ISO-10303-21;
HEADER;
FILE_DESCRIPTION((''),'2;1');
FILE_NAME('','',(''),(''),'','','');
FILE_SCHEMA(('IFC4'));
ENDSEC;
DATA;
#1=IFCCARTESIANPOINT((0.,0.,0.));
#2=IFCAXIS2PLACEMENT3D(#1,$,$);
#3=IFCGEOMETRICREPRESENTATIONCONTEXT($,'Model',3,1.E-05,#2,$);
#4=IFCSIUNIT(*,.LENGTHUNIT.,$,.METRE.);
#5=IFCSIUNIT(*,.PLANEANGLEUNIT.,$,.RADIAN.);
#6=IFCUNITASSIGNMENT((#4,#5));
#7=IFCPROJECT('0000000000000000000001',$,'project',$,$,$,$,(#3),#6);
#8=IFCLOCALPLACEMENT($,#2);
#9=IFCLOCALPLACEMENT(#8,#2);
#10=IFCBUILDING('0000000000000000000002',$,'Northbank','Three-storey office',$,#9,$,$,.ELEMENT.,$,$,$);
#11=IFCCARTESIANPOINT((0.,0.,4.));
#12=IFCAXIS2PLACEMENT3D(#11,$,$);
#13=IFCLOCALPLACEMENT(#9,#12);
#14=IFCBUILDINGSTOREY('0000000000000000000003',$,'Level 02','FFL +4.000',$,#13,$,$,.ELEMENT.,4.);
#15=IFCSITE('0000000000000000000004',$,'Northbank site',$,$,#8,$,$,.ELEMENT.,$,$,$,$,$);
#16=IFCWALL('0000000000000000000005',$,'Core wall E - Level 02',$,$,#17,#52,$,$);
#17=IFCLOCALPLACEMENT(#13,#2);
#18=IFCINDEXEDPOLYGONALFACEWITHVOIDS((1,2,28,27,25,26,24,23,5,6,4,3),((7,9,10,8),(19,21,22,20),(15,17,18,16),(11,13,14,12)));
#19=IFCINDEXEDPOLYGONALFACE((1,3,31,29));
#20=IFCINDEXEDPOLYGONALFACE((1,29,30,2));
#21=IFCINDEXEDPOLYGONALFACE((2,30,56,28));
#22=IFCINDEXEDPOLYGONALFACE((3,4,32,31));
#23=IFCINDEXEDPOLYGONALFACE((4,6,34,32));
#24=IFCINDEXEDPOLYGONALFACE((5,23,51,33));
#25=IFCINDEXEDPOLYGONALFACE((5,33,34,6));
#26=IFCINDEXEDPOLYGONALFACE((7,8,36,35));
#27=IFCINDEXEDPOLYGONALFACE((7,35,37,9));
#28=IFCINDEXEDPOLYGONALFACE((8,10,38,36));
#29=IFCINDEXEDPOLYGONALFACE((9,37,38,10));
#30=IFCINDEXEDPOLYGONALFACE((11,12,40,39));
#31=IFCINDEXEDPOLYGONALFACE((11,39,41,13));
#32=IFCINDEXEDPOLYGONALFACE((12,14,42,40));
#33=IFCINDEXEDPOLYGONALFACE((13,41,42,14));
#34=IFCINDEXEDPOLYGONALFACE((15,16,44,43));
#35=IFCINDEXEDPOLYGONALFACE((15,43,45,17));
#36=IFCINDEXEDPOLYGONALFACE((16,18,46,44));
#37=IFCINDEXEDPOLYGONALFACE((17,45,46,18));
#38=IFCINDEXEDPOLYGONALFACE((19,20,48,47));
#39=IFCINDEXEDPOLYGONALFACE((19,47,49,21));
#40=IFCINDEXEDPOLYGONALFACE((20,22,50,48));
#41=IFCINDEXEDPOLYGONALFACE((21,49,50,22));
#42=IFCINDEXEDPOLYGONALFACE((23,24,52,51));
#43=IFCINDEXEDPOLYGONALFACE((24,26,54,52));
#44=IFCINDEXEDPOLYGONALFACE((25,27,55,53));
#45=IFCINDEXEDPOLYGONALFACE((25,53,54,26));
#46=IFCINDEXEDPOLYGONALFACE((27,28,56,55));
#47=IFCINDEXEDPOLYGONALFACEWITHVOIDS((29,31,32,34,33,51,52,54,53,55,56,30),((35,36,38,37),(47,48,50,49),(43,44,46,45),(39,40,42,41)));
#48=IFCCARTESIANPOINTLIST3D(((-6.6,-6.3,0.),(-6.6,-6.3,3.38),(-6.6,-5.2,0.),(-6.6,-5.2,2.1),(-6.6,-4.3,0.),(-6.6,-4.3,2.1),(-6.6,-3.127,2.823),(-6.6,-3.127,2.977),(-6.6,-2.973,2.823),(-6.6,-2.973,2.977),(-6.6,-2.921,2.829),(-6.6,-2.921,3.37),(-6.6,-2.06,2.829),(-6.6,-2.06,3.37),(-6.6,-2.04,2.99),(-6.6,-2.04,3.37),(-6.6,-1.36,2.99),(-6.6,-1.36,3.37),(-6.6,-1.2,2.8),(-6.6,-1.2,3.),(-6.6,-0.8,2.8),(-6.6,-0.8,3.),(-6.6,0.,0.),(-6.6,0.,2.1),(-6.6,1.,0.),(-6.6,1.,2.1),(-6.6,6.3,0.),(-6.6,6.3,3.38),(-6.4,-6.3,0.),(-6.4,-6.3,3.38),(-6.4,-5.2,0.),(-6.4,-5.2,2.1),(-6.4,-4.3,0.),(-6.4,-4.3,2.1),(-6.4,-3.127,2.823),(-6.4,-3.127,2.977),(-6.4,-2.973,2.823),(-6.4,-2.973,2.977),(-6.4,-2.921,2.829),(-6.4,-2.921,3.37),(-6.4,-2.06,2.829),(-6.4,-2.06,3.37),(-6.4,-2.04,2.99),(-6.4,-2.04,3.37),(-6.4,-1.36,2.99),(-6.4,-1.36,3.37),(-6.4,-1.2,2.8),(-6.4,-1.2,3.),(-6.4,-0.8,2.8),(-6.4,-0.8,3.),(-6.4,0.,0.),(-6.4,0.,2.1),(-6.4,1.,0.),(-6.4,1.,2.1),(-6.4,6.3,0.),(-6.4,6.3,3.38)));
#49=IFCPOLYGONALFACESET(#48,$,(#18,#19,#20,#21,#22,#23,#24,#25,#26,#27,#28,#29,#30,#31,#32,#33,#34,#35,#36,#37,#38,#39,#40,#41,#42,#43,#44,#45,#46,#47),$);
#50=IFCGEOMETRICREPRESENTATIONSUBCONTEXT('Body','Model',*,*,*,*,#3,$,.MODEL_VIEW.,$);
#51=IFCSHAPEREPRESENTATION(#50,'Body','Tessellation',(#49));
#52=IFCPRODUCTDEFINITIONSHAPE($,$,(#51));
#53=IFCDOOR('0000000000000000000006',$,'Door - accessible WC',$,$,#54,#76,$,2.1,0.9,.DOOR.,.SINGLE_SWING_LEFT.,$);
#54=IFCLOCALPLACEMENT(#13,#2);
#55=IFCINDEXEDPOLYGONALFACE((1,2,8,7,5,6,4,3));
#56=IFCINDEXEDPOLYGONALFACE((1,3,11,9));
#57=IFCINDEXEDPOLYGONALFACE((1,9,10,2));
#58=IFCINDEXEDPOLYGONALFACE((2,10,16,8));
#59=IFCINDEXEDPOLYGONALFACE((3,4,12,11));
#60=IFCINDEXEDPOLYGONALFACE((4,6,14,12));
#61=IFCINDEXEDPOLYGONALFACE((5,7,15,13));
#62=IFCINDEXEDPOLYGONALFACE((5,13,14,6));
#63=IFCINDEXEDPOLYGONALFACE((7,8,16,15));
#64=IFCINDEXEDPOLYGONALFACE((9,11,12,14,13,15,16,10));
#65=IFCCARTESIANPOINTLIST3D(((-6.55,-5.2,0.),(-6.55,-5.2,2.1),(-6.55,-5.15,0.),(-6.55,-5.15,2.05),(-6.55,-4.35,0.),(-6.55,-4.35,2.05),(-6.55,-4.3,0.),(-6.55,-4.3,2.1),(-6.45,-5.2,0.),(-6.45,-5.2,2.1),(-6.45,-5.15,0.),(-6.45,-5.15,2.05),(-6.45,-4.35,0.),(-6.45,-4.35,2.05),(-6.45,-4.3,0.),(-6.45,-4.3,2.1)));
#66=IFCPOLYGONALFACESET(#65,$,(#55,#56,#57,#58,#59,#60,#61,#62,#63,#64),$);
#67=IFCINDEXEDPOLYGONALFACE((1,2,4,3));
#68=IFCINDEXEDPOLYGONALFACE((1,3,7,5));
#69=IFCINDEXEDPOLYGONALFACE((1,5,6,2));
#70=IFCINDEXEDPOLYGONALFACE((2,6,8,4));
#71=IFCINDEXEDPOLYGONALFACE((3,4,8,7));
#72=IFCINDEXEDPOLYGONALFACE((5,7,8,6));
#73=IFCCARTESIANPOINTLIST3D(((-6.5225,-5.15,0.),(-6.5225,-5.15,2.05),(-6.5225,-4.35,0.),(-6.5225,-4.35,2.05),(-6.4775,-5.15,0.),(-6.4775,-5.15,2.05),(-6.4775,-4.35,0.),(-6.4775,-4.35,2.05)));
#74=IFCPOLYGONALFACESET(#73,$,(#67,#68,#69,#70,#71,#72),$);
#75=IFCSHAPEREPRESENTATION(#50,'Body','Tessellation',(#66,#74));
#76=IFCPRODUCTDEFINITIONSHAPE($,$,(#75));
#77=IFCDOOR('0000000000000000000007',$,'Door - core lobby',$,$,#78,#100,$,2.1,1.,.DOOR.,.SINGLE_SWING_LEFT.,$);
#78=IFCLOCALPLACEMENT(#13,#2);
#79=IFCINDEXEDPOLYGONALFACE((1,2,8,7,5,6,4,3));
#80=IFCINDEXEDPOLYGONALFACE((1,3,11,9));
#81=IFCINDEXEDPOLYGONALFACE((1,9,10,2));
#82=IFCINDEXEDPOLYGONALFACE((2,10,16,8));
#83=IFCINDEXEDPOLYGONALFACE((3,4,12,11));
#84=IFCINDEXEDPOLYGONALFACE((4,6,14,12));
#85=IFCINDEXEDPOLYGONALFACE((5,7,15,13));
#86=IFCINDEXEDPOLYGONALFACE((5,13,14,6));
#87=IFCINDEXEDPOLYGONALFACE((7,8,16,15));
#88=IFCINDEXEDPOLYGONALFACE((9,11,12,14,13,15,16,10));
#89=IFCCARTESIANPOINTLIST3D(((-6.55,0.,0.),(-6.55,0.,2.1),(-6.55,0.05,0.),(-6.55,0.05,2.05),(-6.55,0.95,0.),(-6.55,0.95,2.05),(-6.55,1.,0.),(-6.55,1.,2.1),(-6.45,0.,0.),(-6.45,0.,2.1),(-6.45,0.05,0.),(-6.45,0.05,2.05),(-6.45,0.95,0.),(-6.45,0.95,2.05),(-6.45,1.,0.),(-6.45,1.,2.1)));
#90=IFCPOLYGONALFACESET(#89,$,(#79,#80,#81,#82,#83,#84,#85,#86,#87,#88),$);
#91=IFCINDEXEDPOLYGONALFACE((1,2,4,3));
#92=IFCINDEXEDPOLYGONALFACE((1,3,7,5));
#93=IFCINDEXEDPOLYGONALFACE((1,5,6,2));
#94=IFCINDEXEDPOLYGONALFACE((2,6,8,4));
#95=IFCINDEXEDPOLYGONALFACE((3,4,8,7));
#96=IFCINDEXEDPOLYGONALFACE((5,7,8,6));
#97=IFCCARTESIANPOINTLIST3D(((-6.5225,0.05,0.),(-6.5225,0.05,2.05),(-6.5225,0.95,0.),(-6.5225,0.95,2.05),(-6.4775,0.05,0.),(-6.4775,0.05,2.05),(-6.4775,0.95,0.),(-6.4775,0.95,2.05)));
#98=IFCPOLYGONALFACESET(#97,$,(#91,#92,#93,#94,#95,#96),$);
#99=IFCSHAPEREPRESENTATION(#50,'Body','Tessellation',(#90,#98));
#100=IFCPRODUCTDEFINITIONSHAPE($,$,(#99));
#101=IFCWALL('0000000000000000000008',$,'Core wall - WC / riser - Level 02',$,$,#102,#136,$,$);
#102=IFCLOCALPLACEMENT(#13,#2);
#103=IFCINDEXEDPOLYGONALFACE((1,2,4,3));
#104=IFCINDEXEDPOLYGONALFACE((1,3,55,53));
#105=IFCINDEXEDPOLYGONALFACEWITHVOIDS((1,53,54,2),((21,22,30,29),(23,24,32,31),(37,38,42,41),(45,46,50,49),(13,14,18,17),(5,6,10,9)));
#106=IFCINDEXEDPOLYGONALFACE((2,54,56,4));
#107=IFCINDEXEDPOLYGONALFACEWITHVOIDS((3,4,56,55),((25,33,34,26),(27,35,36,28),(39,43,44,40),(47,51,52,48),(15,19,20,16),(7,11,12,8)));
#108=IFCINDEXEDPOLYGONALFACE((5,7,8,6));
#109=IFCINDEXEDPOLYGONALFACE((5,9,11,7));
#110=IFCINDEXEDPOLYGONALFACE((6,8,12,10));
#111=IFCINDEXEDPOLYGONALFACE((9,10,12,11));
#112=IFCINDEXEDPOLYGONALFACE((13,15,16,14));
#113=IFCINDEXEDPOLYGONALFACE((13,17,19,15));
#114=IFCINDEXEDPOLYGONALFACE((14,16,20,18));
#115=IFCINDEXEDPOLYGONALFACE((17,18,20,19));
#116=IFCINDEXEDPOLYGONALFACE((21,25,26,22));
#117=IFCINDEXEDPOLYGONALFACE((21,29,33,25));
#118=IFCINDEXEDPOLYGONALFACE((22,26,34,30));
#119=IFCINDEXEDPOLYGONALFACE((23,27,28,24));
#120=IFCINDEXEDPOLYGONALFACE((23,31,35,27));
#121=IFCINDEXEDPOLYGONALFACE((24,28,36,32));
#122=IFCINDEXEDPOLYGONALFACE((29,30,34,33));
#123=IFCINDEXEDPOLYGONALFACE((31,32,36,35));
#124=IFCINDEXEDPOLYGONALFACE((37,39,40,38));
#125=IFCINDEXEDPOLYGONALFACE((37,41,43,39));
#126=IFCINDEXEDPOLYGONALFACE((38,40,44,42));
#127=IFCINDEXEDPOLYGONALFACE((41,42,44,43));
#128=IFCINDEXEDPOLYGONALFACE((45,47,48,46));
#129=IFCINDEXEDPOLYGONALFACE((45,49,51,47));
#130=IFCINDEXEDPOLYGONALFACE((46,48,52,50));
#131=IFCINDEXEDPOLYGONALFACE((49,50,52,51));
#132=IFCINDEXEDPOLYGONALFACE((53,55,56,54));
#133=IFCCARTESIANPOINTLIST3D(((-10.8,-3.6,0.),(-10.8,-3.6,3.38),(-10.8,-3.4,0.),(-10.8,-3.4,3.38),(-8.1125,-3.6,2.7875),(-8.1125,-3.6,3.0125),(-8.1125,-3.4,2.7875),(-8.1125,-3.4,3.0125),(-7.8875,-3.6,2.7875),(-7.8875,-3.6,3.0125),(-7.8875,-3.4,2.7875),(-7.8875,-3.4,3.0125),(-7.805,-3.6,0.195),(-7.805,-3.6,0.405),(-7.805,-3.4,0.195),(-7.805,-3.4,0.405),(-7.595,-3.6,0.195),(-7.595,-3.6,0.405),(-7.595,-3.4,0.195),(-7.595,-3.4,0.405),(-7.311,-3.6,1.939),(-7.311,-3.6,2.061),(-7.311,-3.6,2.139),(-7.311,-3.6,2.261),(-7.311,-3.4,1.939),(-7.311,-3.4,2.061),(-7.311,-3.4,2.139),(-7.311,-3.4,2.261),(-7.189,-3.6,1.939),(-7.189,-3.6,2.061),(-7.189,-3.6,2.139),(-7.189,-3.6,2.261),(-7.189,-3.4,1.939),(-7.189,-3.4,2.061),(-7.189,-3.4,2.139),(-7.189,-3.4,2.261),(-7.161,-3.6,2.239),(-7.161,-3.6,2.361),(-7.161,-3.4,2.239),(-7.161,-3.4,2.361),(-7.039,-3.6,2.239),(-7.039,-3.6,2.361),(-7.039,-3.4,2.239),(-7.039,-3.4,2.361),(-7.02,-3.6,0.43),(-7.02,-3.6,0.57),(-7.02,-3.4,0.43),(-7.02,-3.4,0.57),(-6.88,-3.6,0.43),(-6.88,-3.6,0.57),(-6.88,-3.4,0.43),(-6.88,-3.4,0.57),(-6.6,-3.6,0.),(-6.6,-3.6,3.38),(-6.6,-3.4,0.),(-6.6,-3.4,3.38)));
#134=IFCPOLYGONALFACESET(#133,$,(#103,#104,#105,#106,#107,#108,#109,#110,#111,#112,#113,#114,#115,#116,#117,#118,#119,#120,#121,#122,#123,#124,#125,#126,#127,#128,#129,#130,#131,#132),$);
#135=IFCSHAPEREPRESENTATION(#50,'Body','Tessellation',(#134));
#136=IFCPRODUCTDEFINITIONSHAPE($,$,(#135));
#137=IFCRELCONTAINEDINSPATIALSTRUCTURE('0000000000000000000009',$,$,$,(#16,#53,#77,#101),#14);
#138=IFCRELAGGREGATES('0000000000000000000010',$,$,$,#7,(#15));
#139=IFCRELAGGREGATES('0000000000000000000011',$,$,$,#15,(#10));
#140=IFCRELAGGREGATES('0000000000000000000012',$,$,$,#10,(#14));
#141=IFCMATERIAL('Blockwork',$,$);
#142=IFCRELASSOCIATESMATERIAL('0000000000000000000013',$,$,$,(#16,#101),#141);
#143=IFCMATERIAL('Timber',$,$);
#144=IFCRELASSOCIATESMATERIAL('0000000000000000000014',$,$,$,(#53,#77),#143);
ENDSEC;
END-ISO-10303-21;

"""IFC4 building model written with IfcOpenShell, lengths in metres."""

from ifc_helpers import new_model, si_unit, frame, origin, place, context, subcontext, project, spatial, polyline, outline, extrude, material, element, fill, save


model = new_model("IFC4")

# Units and contexts
model_context = context("Model", 3, precision=1e-05, world=origin())
body_context = subcontext(model_context, "Body", "Model", "MODEL_VIEW")
ifc_project = project(units=[si_unit("LENGTHUNIT", "METRE"), si_unit("PLANEANGLEUNIT", "RADIAN")], contexts=[model_context])

# Site, building, storey
site_placement = place(None, origin())
site = spatial("IfcSite", under=ifc_project, at=site_placement, Name="Northbank site", CompositionType="ELEMENT")
building_placement = place(site_placement, origin())
building = spatial("IfcBuilding", under=site, at=building_placement, Name="Northbank", Description="Three-storey office", CompositionType="ELEMENT")
storey_placement = place(building_placement, frame((0.0, 0.0, 4.0)))
storey = spatial("IfcBuildingStorey", under=building, at=storey_placement, Name="Level 02", Description="FFL +4.000", CompositionType="ELEMENT", Elevation=4.0)

# Wall, openings, doors
ifc_material_1 = material(Name="Blockwork")
wall_1_placement = place(storey_placement, frame((0.0, 0.0, -4.0)))
wall_1 = element("IfcWall", 1, at=wall_1_placement, inside=storey, material=ifc_material_1, Name="Core wall E - Level 02", context=body_context, shape_type="SweptSolid", body=[
    extrude(outline(polyline([(0.0, 0.0), (1.1, 0.0), (1.1, 2.1), (2.0, 2.1), (2.0, 0.0), (6.3, 0.0), (6.3, 2.1), (7.3, 2.1), (7.3, 0.0), (12.6, 0.0), (12.6, 3.38), (0.0, 3.38), (0.0, 0.0)]), holes=[polyline([(3.379, 2.829), (3.379, 3.37), (4.24, 3.37), (4.24, 2.829), (3.379, 2.829)]), polyline([(4.26, 2.99), (4.26, 3.37), (4.94, 3.37), (4.94, 2.99), (4.26, 2.99)]), polyline([(3.173, 2.823), (3.173, 2.977), (3.327, 2.977), (3.327, 2.823), (3.173, 2.823)]), polyline([(5.1, 2.8), (5.1, 3.0), (5.5, 3.0), (5.5, 2.8), (5.1, 2.8)])]), frame((-6.6, -6.3, 4.0), z_axis=(1.0, 0.0, 0.0), x_axis=(0.0, 1.0, 0.0)), (0.0, 0.0, 1.0), 0.2),
])
opening_1_placement = place(storey_placement, frame((0.0, 0.0, -4.0)))
opening_1 = element("IfcOpeningElement", 2, at=opening_1_placement, cuts=wall_1, PredefinedType="OPENING", context=body_context, shape_type="SweptSolid", body=[
    extrude(outline(polyline([(0.0, 0.0), (0.9, 0.0), (0.9, 2.1), (0.0, 2.1), (0.0, 0.0)])), frame((-6.65, -5.2, 4.0), z_axis=(1.0, 0.0, 0.0), x_axis=(0.0, 1.0, 0.0)), (0.0, 0.0, 1.0), 0.3),
])
opening_2_placement = place(storey_placement, frame((0.0, 0.0, -4.0)))
opening_2 = element("IfcOpeningElement", 3, at=opening_2_placement, cuts=wall_1, PredefinedType="OPENING", context=body_context, shape_type="SweptSolid", body=[
    extrude(outline(polyline([(0.0, 0.0), (1.0, 0.0), (1.0, 2.1), (0.0, 2.1), (0.0, 0.0)])), frame((-6.65, 0.0, 4.0), z_axis=(1.0, 0.0, 0.0), x_axis=(0.0, 1.0, 0.0)), (0.0, 0.0, 1.0), 0.3),
])
ifc_material_2 = material(Name="Timber")
door_1_placement = place(storey_placement, frame((0.0, 0.0, -4.0)))
door_1 = element("IfcDoor", 4, at=door_1_placement, inside=storey, material=ifc_material_2, Name="Door - accessible WC", OperationType="SINGLE_SWING_LEFT", OverallHeight=2.1, OverallWidth=0.9, PredefinedType="DOOR", context=body_context, shape_type="SweptSolid", body=[
    extrude(outline(polyline([(0.0, 0.0), (0.05, 0.0), (0.05, 2.05), (0.85, 2.05), (0.85, 0.0), (0.9, 0.0), (0.9, 2.1), (0.0, 2.1), (0.0, 0.0)])), frame((-6.55, -5.2, 4.0), z_axis=(1.0, 0.0, 0.0), x_axis=(0.0, 1.0, 0.0)), (0.0, 0.0, 1.0), 0.1),
    extrude(outline(polyline([(0.0, 0.0), (0.8, 0.0), (0.8, 2.05), (0.0, 2.05), (0.0, 0.0)])), frame((-6.5225, -5.15, 4.0), z_axis=(1.0, 0.0, 0.0), x_axis=(0.0, 1.0, 0.0)), (0.0, 0.0, 1.0), 0.045),
])
fill(opening_1, door_1)
door_2_placement = place(storey_placement, frame((0.0, 0.0, -4.0)))
door_2 = element("IfcDoor", 5, at=door_2_placement, inside=storey, material=ifc_material_2, Name="Door - core lobby", OperationType="SINGLE_SWING_LEFT", OverallHeight=2.1, OverallWidth=1.0, PredefinedType="DOOR", context=body_context, shape_type="SweptSolid", body=[
    extrude(outline(polyline([(0.0, 0.0), (0.05, 0.0), (0.05, 2.05), (0.95, 2.05), (0.95, 0.0), (1.0, 0.0), (1.0, 2.1), (0.0, 2.1), (0.0, 0.0)])), frame((-6.55, 0.0, 4.0), z_axis=(1.0, 0.0, 0.0), x_axis=(0.0, 1.0, 0.0)), (0.0, 0.0, 1.0), 0.1),
    extrude(outline(polyline([(0.0, 0.0), (0.9, 0.0), (0.9, 2.05), (0.0, 2.05), (0.0, 0.0)])), frame((-6.5225, 0.05, 4.0), z_axis=(1.0, 0.0, 0.0), x_axis=(0.0, 1.0, 0.0)), (0.0, 0.0, 1.0), 0.045),
])
fill(opening_2, door_2)

# Wall
wall_2_placement = place(storey_placement, frame((0.0, 0.0, -4.0)))
element("IfcWall", 6, at=wall_2_placement, inside=storey, material=ifc_material_1, Name="Core wall - WC / riser - Level 02", context=body_context, shape_type="SweptSolid", body=[
    extrude(outline(polyline([(0.0, 0.0), (4.2, 0.0), (4.2, 3.38), (0.0, 3.38), (0.0, 0.0)]), holes=[polyline([(2.6875, 2.7875), (2.6875, 3.0125), (2.9125, 3.0125), (2.9125, 2.7875), (2.6875, 2.7875)]), polyline([(3.489, 1.939), (3.489, 2.061), (3.611, 2.061), (3.611, 1.939), (3.489, 1.939)]), polyline([(3.489, 2.139), (3.489, 2.261), (3.611, 2.261), (3.611, 2.139), (3.489, 2.139)]), polyline([(3.639, 2.239), (3.639, 2.361), (3.761, 2.361), (3.761, 2.239), (3.639, 2.239)]), polyline([(2.995, 0.195), (2.995, 0.405), (3.205, 0.405), (3.205, 0.195), (2.995, 0.195)]), polyline([(3.78, 0.43), (3.78, 0.57), (3.92, 0.57), (3.92, 0.43), (3.78, 0.43)])]), frame((-10.8, -3.4, 4.0), z_axis=(0.0, -1.0, 0.0), x_axis=(1.0, 0.0, 0.0)), (0.0, 0.0, 1.0), 0.2),
])

save(model, "model.ifc")
